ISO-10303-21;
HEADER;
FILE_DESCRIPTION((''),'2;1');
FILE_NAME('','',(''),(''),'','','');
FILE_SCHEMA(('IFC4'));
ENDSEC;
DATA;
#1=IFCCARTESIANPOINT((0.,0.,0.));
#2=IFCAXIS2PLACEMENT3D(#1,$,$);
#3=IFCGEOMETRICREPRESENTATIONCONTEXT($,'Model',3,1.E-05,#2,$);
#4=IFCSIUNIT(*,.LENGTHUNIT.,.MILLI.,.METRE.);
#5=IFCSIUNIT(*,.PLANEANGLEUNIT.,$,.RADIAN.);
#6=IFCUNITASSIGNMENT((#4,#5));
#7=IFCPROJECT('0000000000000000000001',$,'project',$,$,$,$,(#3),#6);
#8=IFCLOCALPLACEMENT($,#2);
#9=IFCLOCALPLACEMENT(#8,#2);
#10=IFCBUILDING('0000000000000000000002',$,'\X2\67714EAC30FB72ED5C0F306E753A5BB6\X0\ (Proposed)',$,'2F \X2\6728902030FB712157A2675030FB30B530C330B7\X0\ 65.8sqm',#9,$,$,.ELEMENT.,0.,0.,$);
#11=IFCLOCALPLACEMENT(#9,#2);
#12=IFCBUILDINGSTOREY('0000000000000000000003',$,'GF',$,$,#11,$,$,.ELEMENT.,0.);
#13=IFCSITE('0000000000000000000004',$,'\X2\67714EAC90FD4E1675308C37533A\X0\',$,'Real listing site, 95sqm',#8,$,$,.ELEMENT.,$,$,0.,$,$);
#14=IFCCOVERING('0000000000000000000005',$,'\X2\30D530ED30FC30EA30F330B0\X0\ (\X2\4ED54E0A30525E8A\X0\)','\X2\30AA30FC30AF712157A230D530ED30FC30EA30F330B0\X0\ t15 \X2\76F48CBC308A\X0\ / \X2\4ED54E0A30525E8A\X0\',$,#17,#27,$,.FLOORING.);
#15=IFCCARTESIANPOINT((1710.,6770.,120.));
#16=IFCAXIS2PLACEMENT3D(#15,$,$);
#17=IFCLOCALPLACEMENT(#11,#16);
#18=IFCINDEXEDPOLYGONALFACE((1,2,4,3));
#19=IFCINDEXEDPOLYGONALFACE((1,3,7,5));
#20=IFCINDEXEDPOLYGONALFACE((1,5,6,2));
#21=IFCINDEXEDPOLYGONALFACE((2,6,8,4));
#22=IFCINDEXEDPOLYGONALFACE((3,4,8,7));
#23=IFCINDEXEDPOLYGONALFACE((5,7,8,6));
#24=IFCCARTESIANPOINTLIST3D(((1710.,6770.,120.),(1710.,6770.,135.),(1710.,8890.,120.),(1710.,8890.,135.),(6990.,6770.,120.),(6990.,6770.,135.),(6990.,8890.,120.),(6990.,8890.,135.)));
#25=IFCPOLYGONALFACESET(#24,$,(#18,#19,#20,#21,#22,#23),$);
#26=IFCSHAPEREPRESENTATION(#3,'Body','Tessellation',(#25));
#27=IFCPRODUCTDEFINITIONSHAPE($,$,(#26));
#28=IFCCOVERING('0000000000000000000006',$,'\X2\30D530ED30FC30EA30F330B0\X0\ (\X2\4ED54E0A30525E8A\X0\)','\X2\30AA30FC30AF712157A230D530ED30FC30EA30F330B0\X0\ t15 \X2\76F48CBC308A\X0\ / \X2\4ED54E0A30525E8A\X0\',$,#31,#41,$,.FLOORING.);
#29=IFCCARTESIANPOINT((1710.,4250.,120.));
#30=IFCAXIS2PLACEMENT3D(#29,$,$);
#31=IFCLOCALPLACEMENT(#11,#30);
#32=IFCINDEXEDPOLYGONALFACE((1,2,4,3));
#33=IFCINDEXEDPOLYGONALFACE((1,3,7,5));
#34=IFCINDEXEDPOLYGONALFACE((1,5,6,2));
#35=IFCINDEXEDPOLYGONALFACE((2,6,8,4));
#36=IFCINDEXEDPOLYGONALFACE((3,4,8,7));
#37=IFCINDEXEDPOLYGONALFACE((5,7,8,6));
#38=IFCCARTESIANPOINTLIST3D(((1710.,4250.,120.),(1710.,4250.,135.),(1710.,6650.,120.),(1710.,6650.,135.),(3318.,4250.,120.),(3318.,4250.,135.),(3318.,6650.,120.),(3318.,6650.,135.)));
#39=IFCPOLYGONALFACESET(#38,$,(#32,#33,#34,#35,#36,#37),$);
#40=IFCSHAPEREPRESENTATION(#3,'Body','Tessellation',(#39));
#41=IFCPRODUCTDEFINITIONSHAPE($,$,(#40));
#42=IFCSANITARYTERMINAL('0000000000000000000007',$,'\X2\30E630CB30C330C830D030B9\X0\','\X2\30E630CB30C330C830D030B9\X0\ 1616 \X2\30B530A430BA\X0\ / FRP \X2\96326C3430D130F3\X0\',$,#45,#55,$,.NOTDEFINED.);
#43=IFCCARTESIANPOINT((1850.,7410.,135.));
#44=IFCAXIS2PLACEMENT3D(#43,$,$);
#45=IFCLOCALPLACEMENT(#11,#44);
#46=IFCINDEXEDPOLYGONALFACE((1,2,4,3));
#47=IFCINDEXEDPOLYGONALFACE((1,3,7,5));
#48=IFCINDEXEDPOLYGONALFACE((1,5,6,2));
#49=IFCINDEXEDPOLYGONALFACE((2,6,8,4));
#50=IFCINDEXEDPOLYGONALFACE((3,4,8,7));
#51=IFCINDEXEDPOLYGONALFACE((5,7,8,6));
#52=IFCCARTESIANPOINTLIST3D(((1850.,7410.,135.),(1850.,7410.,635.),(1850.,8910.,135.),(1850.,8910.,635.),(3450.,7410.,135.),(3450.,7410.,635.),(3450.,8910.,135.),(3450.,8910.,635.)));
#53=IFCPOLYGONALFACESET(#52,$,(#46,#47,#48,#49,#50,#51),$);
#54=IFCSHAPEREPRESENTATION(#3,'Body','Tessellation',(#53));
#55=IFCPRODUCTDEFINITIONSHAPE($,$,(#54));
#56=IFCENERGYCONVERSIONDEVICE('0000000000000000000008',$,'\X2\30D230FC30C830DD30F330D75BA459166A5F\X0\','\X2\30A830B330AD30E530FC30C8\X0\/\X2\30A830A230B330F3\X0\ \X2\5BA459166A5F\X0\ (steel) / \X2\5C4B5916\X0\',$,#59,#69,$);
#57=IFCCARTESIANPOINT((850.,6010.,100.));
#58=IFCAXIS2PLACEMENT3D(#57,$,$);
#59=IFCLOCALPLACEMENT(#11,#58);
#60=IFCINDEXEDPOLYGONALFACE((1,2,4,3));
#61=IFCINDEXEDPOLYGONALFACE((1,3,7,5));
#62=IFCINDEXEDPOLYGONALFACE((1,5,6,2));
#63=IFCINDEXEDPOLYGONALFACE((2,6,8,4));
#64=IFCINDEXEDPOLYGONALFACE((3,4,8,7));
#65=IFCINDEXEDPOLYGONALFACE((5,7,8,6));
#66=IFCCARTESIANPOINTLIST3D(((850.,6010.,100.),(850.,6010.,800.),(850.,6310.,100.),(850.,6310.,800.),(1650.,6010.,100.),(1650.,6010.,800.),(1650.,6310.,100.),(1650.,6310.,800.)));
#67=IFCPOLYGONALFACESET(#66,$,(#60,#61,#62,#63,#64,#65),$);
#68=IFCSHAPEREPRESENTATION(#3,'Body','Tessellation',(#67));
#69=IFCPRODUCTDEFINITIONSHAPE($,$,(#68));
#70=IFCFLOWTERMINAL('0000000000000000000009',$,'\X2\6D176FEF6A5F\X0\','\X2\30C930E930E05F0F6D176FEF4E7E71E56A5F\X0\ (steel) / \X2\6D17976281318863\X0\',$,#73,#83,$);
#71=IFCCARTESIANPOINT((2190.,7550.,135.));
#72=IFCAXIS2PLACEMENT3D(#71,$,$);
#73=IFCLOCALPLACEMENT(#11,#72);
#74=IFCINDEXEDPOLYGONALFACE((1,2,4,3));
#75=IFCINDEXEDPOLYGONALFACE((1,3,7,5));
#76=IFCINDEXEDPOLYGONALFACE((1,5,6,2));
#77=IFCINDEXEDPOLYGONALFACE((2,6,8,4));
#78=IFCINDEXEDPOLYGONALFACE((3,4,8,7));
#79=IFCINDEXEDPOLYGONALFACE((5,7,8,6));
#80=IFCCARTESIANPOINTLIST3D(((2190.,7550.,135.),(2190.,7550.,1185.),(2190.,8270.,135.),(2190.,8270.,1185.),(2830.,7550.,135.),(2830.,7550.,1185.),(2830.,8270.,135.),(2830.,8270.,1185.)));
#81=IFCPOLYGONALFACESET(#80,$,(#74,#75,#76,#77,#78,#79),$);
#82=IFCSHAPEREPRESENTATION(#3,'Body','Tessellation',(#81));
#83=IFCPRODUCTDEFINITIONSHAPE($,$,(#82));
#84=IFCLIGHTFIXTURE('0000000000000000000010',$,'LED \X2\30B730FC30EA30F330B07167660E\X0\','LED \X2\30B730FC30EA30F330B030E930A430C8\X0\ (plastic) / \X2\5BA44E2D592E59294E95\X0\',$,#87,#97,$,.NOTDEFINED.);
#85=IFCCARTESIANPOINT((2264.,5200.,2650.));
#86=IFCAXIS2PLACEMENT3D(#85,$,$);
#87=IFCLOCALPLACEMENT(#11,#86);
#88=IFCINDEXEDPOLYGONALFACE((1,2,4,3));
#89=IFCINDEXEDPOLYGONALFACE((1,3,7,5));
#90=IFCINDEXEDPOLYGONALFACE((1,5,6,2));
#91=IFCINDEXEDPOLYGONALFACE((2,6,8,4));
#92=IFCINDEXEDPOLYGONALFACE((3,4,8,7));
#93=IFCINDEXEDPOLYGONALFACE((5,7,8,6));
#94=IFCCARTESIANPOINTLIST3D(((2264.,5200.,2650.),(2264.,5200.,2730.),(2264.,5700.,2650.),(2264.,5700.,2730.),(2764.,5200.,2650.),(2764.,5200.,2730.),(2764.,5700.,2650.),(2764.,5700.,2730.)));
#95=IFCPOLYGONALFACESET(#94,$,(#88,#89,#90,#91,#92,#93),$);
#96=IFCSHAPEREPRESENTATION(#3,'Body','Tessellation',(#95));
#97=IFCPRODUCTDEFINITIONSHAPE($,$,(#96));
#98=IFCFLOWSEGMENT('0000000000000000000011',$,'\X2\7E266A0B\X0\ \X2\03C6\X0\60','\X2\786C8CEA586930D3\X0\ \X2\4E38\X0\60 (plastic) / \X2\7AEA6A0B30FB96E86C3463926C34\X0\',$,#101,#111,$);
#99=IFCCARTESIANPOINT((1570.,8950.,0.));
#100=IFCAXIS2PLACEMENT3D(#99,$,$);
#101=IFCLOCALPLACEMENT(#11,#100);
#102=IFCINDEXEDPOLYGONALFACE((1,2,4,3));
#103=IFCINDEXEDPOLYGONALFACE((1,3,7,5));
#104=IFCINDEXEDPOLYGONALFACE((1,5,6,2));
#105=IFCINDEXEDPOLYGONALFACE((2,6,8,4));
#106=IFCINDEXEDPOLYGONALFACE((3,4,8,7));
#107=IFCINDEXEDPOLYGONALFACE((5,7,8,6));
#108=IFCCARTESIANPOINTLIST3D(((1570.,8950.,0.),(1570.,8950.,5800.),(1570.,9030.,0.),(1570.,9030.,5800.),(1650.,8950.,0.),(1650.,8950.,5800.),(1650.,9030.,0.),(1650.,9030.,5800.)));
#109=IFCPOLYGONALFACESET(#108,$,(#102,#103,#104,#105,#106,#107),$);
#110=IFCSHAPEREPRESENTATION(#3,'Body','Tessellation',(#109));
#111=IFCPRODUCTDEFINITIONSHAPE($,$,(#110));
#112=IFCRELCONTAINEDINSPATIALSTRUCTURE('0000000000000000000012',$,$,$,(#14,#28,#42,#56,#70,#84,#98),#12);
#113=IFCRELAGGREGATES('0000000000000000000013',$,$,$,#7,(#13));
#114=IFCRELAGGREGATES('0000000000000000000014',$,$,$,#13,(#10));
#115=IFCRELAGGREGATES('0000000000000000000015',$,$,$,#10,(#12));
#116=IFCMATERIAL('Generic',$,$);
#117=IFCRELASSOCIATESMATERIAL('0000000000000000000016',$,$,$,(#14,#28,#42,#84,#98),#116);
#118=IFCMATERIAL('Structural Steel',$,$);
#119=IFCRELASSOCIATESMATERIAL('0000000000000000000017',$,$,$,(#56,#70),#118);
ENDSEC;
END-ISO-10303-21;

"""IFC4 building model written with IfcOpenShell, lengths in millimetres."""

from ifc_helpers import new_model, si_unit, frame, frame_2d, origin, place, context, project, spatial, rectangle, extrude, material, element, save


model = new_model("IFC4")

# Units and contexts
model_context = context("Model", 3, precision=1e-05, world=origin())
ifc_project = project(units=[si_unit("LENGTHUNIT", "METRE", prefix="MILLI"), si_unit("PLANEANGLEUNIT", "RADIAN")], contexts=[model_context])

# Site, building, storey
site_placement = place(None, origin())
site = spatial("IfcSite", under=ifc_project, at=site_placement, Name="東京都世田谷区", ObjectType="Real listing site, 95sqm", CompositionType="ELEMENT", RefElevation=0.0)
building_placement = place(site_placement, origin())
building = spatial("IfcBuilding", under=site, at=building_placement, Name="東京・狭小の町家 (Proposed)", ObjectType="2F 木造・無垢材・サッシ 65.8sqm", CompositionType="ELEMENT", ElevationOfRefHeight=0.0, ElevationOfTerrain=0.0)
storey_placement = place(building_placement, origin())
storey = spatial("IfcBuildingStorey", under=building, at=storey_placement, Name="GF", CompositionType="ELEMENT", Elevation=0.0)

# Coverings
ifc_material_1 = material(Name="Generic")
covering_1_placement = place(storey_placement, frame((1710.0, 6770.0, 120.0)))
element("IfcCovering", 1, at=covering_1_placement, inside=storey, material=ifc_material_1, Name="フローリング (仕上げ床)", Description="オーク無垢フローリング t15 直貼り / 仕上げ床", PredefinedType="FLOORING", context=model_context, shape_type="SweptSolid", body=[
    extrude(rectangle(XDim=5280.0, YDim=2120.0, at=frame_2d((2640.0, 1060.0))), frame((1710.0, 6770.0, 120.0)), (0.0, 0.0, 1.0), 15.0),
])
covering_2_placement = place(storey_placement, frame((1710.0, 4250.0, 120.0)))
element("IfcCovering", 2, at=covering_2_placement, inside=storey, material=ifc_material_1, Name="フローリング (仕上げ床)", Description="オーク無垢フローリング t15 直貼り / 仕上げ床", PredefinedType="FLOORING", context=model_context, shape_type="SweptSolid", body=[
    extrude(rectangle(XDim=1608.0, YDim=2400.0, at=frame_2d((804.0, 1200.0))), frame((1710.0, 4250.0, 120.0)), (0.0, 0.0, 1.0), 15.0),
])

# Sanitary terminal
sanitary_terminal_placement = place(storey_placement, frame((1850.0, 7410.0, 135.0)))
element("IfcSanitaryTerminal", 3, at=sanitary_terminal_placement, inside=storey, material=ifc_material_1, Name="ユニットバス", Description="ユニットバス 1616 サイズ / FRP 防水パン", PredefinedType="NOTDEFINED", context=model_context, shape_type="SweptSolid", body=[
    extrude(rectangle(XDim=1600.0, YDim=1500.0, at=frame_2d((800.0, 750.0))), frame((1850.0, 7410.0, 135.0)), (0.0, 0.0, 1.0), 500.0),
])

# Shared definitions
ifc_material_2 = material(Name="Structural Steel")

# Energy conversion device
energy_conversion_device_placement = place(storey_placement, frame((850.0, 6010.0, 100.0)))
element("IfcEnergyConversionDevice", 4, at=energy_conversion_device_placement, inside=storey, material=ifc_material_2, Name="ヒートポンプ室外機", Description="エコキュート/エアコン 室外機 (steel) / 屋外", context=model_context, shape_type="SweptSolid", body=[
    extrude(rectangle(XDim=800.0, YDim=300.0, at=frame_2d((400.0, 150.0))), frame((850.0, 6010.0, 100.0)), (0.0, 0.0, 1.0), 700.0),
])

# Flow terminal
flow_terminal_placement = place(storey_placement, frame((2190.0, 7550.0, 135.0)))
element("IfcFlowTerminal", 5, at=flow_terminal_placement, inside=storey, material=ifc_material_2, Name="洗濯機", Description="ドラム式洗濯乾燥機 (steel) / 洗面脱衣", context=model_context, shape_type="SweptSolid", body=[
    extrude(rectangle(XDim=640.0, YDim=720.0, at=frame_2d((320.0, 360.0))), frame((2190.0, 7550.0, 135.0)), (0.0, 0.0, 1.0), 1050.0),
])

# Light fixture
light_fixture_placement = place(storey_placement, frame((2264.0, 5200.0, 2650.0)))
element("IfcLightFixture", 6, at=light_fixture_placement, inside=storey, material=ifc_material_1, Name="LED シーリング照明", Description="LED シーリングライト (plastic) / 室中央天井", PredefinedType="NOTDEFINED", context=model_context, shape_type="SweptSolid", body=[
    extrude(rectangle(XDim=500.0, YDim=500.0, at=frame_2d((250.0, 250.0))), frame((2264.0, 5200.0, 2650.0)), (0.0, 0.0, 1.0), 80.0),
])

# Flow segment
flow_segment_placement = place(storey_placement, frame((1570.0, 8950.0, 0.0)))
element("IfcFlowSegment", 7, at=flow_segment_placement, inside=storey, material=ifc_material_1, Name="縦樋 φ60", Description="硬質塩ビ 丸60 (plastic) / 竪樋・雨水排水", context=model_context, shape_type="SweptSolid", body=[
    extrude(rectangle(XDim=80.0, YDim=80.0, at=frame_2d((40.0, 40.0))), frame((1570.0, 8950.0, 0.0)), (0.0, 0.0, 1.0), 5800.0),
])

save(model, "model.ifc")
